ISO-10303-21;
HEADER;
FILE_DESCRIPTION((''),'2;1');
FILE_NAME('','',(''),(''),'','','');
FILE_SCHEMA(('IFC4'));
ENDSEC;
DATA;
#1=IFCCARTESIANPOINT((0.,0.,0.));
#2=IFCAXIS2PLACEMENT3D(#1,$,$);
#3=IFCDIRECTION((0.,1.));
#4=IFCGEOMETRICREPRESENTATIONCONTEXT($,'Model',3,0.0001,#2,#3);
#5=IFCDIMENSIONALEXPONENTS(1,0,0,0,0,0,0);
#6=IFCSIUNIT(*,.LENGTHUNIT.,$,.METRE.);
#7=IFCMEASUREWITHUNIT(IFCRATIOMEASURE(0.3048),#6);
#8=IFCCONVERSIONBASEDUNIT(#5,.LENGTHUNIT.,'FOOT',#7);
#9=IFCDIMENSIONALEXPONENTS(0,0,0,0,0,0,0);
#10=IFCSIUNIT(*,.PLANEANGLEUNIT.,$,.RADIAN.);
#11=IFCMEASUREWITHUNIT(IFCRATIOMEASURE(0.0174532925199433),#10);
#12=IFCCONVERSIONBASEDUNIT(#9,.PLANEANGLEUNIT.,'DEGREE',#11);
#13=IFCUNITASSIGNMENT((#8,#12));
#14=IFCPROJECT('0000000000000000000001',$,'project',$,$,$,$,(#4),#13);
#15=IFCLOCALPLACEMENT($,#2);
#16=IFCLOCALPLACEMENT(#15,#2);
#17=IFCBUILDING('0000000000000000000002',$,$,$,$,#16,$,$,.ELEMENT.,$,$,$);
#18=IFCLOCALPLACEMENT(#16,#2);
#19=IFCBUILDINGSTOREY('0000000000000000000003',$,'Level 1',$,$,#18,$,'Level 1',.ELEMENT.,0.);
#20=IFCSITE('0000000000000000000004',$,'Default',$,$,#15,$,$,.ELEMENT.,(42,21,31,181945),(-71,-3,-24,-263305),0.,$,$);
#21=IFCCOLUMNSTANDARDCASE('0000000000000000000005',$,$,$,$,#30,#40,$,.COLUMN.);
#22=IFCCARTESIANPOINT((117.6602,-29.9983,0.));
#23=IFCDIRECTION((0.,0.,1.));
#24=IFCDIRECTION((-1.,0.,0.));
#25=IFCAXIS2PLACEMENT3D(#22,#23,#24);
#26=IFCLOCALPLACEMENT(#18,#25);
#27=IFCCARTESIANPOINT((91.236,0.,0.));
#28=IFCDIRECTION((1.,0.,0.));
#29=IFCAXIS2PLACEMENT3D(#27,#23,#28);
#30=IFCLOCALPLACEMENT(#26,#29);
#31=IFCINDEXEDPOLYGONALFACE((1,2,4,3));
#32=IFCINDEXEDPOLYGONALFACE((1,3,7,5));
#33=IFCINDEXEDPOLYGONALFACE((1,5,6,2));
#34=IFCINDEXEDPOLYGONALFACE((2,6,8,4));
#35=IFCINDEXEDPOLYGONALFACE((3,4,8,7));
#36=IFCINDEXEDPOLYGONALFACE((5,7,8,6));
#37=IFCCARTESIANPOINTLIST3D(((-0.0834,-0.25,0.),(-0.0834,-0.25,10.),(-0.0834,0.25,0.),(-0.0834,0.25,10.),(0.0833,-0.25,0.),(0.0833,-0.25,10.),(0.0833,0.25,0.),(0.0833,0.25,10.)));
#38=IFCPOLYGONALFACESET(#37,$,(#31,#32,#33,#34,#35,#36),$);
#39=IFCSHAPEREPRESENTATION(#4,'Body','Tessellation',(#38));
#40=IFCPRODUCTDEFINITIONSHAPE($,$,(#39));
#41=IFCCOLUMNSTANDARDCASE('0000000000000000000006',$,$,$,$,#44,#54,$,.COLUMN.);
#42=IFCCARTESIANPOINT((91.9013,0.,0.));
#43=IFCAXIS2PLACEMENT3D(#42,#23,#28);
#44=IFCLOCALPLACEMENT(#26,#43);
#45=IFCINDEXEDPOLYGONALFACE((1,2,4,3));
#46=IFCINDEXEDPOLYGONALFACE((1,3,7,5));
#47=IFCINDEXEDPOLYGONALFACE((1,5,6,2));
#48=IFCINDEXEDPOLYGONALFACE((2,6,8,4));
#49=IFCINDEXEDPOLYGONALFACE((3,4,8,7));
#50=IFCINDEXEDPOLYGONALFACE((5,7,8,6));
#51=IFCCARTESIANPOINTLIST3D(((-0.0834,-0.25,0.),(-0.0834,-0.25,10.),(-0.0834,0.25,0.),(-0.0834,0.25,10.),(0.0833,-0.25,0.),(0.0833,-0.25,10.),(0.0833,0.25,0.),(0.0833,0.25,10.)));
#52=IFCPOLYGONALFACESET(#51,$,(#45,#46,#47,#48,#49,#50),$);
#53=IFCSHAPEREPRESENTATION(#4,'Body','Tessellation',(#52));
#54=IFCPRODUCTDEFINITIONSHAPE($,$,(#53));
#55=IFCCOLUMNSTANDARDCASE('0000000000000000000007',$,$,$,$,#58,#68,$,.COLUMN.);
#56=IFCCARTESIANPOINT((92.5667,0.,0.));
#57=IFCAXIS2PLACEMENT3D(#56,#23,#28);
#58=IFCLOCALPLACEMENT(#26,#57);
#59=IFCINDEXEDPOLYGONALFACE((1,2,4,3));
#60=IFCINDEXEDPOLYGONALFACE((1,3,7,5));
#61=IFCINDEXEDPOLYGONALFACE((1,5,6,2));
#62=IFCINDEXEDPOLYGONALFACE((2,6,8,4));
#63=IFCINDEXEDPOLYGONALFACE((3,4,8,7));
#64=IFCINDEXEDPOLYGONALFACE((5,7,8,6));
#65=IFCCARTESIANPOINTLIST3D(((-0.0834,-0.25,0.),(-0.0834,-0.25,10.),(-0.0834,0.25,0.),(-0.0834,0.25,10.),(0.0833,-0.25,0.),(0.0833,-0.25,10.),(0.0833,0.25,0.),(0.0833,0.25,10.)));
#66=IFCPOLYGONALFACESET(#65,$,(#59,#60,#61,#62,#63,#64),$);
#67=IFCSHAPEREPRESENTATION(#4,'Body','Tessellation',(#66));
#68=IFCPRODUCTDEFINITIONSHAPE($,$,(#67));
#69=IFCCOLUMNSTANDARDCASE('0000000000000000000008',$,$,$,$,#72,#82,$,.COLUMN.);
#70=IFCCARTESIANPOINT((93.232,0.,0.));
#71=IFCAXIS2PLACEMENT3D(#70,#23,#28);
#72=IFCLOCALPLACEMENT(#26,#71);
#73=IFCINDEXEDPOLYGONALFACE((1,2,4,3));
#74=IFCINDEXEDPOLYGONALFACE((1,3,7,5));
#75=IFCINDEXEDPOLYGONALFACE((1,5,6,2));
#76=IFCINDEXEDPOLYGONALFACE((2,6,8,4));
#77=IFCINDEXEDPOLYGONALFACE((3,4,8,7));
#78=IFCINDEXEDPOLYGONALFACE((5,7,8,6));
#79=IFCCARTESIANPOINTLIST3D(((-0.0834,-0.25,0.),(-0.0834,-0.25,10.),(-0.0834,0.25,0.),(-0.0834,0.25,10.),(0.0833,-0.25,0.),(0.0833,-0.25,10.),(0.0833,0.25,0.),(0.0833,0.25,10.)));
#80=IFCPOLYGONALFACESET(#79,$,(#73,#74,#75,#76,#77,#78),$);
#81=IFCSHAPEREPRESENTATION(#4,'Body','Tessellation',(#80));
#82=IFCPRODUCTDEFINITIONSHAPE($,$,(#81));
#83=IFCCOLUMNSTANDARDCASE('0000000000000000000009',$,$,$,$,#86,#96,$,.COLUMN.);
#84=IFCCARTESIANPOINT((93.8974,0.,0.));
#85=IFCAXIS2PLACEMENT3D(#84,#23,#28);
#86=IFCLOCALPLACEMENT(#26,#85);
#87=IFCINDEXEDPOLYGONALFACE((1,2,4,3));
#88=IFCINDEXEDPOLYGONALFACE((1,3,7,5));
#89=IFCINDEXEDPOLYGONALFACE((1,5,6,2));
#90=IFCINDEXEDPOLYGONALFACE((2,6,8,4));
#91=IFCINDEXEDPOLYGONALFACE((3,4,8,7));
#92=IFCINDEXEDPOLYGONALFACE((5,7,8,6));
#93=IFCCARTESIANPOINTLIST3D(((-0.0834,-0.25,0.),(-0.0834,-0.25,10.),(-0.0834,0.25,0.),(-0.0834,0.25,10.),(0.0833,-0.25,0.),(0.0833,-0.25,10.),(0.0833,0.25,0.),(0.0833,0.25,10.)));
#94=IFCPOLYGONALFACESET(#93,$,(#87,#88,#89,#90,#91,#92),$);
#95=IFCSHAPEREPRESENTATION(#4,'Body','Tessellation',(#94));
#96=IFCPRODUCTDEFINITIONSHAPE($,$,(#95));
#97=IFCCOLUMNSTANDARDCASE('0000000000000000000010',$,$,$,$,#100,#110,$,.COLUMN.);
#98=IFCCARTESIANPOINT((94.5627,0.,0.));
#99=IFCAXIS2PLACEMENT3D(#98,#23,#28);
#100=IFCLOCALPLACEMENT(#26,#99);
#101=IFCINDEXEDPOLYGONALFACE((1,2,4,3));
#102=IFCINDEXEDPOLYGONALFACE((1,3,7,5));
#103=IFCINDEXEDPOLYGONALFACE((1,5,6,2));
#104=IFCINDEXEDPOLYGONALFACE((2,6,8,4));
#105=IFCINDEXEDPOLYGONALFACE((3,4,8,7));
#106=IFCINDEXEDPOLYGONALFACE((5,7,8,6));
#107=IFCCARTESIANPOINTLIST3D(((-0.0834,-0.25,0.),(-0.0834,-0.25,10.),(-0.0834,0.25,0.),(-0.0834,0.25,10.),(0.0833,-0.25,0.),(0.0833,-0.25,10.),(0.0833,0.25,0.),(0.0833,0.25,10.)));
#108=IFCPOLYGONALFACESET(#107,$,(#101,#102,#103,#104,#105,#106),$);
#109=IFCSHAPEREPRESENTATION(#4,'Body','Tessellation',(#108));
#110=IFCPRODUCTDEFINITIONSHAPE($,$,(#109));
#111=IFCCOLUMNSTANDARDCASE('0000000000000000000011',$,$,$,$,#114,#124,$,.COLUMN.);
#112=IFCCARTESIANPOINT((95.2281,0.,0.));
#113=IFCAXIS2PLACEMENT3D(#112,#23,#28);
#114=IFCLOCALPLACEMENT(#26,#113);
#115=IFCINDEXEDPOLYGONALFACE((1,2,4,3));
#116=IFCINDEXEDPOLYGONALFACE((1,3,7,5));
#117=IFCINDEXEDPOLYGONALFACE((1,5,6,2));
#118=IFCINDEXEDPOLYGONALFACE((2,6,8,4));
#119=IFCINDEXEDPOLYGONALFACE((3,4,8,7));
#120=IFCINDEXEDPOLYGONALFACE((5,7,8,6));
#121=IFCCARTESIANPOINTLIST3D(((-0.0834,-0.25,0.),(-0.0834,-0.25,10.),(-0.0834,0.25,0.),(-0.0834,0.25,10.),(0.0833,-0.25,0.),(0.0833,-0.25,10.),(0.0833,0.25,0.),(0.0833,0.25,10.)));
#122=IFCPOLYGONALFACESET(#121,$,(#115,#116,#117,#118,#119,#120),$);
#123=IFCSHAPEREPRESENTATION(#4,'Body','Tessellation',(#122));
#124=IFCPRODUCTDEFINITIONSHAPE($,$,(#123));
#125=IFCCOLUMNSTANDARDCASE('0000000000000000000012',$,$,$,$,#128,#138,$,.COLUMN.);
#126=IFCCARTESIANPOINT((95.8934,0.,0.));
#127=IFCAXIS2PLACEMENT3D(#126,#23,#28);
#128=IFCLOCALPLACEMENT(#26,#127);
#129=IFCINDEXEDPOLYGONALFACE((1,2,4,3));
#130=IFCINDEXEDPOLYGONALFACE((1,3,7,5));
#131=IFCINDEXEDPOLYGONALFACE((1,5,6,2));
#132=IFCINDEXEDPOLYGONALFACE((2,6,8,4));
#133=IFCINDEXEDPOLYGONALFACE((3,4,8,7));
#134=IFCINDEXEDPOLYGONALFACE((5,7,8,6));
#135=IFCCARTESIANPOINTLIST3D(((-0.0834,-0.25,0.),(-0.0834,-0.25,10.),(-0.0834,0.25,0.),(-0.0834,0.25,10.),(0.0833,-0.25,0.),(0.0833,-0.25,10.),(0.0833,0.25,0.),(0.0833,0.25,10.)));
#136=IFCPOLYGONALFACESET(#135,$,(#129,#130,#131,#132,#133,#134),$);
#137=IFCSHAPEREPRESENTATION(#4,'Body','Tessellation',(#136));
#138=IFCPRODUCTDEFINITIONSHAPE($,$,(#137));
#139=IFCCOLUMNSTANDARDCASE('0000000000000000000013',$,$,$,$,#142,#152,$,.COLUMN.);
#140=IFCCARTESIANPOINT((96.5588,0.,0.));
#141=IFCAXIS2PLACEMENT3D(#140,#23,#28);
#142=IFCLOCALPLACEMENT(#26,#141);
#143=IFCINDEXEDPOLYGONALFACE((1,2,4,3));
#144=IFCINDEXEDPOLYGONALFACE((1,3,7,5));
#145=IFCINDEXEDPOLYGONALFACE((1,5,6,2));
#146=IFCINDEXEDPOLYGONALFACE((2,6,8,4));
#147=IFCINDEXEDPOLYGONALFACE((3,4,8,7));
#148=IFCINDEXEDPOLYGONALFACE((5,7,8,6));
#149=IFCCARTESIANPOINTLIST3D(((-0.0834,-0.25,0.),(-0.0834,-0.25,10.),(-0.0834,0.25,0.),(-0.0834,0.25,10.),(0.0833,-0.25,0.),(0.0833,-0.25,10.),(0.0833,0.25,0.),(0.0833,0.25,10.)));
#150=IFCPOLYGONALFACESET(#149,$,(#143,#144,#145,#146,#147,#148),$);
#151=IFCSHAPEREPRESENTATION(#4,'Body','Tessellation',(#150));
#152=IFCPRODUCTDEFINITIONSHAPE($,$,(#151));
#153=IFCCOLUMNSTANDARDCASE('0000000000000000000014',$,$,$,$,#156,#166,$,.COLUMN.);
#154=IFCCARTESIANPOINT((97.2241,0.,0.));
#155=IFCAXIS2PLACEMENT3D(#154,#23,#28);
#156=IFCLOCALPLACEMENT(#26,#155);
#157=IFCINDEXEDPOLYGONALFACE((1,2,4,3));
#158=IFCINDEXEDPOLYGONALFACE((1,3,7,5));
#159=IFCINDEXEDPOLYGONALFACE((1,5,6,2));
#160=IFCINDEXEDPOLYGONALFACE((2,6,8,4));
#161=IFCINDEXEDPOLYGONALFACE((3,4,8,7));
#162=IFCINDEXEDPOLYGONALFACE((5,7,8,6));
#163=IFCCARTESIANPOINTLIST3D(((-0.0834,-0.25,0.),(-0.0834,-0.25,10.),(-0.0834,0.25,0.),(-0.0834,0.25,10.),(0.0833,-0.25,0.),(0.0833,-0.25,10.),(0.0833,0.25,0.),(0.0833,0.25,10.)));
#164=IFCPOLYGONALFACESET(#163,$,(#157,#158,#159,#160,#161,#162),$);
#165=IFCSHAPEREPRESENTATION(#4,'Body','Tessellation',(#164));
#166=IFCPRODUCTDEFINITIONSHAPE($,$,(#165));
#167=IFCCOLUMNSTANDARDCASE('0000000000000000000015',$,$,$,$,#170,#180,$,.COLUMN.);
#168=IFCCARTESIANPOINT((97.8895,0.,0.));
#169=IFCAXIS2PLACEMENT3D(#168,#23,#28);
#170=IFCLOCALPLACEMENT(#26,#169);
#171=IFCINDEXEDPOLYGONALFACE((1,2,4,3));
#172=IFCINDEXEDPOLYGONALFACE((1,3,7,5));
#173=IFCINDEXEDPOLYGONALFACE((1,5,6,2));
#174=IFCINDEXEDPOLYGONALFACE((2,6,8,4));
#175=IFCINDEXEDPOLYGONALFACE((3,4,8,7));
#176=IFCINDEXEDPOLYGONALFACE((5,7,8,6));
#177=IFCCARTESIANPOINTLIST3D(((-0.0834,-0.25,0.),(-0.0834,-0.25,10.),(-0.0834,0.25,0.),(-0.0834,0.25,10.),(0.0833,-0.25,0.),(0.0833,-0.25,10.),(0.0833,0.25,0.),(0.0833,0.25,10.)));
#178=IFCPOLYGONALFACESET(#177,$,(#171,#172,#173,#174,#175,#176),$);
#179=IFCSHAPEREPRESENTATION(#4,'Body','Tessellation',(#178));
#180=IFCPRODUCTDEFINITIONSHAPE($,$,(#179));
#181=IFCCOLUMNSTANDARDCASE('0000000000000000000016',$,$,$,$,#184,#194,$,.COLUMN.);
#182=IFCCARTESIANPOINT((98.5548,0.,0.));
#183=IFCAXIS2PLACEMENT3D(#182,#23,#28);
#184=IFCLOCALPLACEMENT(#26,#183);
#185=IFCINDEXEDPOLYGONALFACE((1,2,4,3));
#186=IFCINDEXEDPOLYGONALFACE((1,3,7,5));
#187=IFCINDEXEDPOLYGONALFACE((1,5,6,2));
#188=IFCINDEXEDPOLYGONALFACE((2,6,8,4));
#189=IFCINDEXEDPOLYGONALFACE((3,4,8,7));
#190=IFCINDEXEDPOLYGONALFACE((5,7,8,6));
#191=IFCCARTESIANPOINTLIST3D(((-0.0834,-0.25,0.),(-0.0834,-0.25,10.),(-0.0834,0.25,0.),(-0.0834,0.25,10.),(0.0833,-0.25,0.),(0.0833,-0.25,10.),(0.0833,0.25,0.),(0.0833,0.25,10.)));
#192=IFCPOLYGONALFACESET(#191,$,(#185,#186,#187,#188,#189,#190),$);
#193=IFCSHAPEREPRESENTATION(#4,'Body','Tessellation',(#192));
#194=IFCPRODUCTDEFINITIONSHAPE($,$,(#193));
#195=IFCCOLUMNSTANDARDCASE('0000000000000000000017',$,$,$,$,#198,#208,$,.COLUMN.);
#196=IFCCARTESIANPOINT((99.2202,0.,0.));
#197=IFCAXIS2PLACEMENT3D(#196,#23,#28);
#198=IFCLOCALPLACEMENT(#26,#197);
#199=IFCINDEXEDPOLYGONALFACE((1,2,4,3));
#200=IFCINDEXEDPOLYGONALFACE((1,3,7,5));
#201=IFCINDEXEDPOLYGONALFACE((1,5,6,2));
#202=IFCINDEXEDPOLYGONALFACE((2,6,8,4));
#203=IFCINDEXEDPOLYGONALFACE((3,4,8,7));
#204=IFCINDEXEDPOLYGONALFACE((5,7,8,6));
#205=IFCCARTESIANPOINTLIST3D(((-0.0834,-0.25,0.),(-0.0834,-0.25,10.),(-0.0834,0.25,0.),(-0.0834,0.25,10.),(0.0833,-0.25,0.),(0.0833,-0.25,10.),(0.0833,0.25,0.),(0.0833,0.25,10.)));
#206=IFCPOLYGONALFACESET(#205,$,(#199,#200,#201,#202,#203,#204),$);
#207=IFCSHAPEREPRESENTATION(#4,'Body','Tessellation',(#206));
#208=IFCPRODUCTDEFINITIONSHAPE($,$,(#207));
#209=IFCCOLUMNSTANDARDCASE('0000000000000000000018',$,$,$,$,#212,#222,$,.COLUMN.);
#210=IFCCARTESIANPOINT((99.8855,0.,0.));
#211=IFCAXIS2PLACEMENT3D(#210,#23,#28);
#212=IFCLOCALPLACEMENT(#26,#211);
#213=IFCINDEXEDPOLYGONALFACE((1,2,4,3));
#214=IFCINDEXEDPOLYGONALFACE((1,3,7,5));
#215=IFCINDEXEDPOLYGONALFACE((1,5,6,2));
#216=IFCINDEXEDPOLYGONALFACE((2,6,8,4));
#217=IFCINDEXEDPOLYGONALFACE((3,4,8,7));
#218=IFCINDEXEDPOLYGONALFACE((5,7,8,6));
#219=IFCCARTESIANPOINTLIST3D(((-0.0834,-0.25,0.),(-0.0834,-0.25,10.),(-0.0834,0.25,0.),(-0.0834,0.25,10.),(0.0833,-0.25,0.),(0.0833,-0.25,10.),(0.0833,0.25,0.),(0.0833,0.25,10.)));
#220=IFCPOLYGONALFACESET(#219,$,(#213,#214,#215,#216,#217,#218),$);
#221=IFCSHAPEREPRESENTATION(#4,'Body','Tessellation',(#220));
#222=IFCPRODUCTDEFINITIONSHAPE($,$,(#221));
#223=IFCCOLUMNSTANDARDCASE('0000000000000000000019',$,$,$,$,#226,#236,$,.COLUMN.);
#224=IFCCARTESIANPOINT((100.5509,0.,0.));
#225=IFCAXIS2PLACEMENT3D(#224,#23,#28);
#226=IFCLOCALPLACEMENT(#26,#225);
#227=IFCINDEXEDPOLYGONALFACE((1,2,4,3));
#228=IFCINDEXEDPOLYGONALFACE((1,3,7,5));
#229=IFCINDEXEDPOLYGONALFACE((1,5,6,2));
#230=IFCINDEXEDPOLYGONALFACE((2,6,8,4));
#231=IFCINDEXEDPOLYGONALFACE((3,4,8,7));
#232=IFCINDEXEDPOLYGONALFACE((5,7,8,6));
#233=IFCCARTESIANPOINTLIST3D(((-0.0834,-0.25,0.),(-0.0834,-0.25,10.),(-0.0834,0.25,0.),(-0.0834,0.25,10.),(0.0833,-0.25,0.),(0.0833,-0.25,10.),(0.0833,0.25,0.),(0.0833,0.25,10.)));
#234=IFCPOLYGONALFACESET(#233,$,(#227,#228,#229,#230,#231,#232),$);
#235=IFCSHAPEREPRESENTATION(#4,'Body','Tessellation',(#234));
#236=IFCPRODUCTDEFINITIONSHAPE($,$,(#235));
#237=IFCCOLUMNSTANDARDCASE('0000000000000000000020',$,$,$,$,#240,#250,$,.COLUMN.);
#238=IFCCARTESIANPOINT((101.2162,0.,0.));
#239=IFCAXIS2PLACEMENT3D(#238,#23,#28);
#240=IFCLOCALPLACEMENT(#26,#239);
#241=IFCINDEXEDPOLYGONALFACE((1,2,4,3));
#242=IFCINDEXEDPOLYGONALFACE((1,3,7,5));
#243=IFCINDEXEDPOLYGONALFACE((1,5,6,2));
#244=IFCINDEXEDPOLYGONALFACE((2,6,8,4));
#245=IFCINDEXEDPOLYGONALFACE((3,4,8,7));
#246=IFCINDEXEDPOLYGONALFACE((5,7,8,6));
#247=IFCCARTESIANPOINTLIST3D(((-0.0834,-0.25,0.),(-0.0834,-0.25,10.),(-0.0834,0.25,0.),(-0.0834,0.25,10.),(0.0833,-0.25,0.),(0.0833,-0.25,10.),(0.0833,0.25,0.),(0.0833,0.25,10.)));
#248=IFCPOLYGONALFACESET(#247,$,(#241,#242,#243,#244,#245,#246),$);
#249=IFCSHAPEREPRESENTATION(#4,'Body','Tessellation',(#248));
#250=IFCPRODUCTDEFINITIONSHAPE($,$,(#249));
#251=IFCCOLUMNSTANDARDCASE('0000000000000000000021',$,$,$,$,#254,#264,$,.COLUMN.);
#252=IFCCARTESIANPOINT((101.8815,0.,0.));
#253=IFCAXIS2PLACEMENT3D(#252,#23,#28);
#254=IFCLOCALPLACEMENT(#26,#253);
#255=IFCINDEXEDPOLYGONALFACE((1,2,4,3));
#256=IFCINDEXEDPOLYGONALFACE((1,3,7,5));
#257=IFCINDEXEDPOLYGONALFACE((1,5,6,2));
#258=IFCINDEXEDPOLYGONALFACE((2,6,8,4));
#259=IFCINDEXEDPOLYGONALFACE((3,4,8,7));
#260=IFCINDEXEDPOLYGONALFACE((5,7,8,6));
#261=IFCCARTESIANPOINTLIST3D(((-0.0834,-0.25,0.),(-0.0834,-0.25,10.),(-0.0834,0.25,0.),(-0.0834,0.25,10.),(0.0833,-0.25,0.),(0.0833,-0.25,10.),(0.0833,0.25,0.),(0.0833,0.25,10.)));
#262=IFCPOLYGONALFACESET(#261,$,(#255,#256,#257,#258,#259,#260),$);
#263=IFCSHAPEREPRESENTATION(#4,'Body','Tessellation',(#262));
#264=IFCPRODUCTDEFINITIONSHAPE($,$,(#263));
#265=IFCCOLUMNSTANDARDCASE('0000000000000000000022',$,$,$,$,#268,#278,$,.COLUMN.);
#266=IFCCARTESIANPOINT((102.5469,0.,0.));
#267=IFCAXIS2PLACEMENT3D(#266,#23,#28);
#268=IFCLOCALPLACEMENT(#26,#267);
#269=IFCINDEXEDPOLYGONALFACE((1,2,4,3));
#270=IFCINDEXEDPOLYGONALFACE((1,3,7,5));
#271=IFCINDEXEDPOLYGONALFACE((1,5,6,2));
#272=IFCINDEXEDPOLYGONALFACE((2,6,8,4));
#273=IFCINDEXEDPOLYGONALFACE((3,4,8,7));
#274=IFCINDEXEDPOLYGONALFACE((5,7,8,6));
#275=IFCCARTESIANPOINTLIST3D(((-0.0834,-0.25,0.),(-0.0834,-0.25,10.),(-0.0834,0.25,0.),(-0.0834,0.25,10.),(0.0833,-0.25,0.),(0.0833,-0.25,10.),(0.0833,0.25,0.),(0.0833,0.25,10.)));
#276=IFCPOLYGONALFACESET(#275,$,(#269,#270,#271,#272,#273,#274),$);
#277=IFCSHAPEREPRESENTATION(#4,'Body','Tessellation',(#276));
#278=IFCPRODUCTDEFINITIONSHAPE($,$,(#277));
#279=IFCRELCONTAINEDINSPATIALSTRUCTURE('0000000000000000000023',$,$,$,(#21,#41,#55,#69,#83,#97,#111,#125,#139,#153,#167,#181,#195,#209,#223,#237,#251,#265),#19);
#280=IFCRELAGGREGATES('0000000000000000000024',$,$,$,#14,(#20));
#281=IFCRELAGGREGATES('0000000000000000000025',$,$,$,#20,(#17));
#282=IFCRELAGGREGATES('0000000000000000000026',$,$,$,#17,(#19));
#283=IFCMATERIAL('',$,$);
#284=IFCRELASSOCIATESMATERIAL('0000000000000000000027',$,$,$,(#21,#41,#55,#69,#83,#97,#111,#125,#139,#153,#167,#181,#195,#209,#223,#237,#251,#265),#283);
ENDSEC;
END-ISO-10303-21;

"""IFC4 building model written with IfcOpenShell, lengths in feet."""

from ifc_helpers import new_model, entity, si_unit, converted_unit, direction, frame, origin, place, context, project, spatial, rectangle, extrude, material, element, save


model = new_model("IFC4")

# Units and contexts
model_context = context("Model", 3, precision=0.0001, world=origin(), true_north=direction((0.0, 1.0)))
ifc_project = project(units=[converted_unit("LENGTHUNIT", "FOOT", entity("IfcRatioMeasure", 0.3048), si_unit("LENGTHUNIT", "METRE"), dimensions=[1, 0, 0, 0, 0, 0, 0]), converted_unit("PLANEANGLEUNIT", "DEGREE", entity("IfcRatioMeasure", 0.0174532925199433), si_unit("PLANEANGLEUNIT", "RADIAN"), dimensions=[0, 0, 0, 0, 0, 0, 0])], contexts=[model_context])

# Site, building, storey
site_placement = place(None, origin())
site = spatial("IfcSite", under=ifc_project, at=site_placement, Name="Default", CompositionType="ELEMENT", RefLatitude=(42, 21, 31, 181945), RefLongitude=(-71, -3, -24, -263305), RefElevation=0.0)
building_placement = place(site_placement, origin())
building = spatial("IfcBuilding", under=site, at=building_placement, CompositionType="ELEMENT")
storey_placement = place(building_placement, origin())
storey = spatial("IfcBuildingStorey", under=building, at=storey_placement, Name="Level 1", LongName="Level 1", CompositionType="ELEMENT", Elevation=0.0)

# Columns
ifc_material = material(Name="")
placement = place(storey_placement, frame((117.6602, -29.9983, 0.0), z_axis=(0.0, 0.0, 1.0), x_axis=(-1.0, 0.0, 0.0)))
for number, where, z_axis, x_axis in (
    (1, (91.236, 0.0, 0.0), (0.0, 0.0, 1.0), (1.0, 0.0, 0.0)),
    (2, (91.9013, 0.0, 0.0), (0.0, 0.0, 1.0), (1.0, 0.0, 0.0)),
    (3, (92.5667, 0.0, 0.0), (0.0, 0.0, 1.0), (1.0, 0.0, 0.0)),
    (4, (93.232, 0.0, 0.0), (0.0, 0.0, 1.0), (1.0, 0.0, 0.0)),
    (5, (93.8974, 0.0, 0.0), (0.0, 0.0, 1.0), (1.0, 0.0, 0.0)),
    (6, (94.5627, 0.0, 0.0), (0.0, 0.0, 1.0), (1.0, 0.0, 0.0)),
    (7, (95.2281, 0.0, 0.0), (0.0, 0.0, 1.0), (1.0, 0.0, 0.0)),
    (8, (95.8934, 0.0, 0.0), (0.0, 0.0, 1.0), (1.0, 0.0, 0.0)),
    (9, (96.5588, 0.0, 0.0), (0.0, 0.0, 1.0), (1.0, 0.0, 0.0)),
    (10, (97.2241, 0.0, 0.0), (0.0, 0.0, 1.0), (1.0, 0.0, 0.0)),
    (11, (97.8895, 0.0, 0.0), (0.0, 0.0, 1.0), (1.0, 0.0, 0.0)),
    (12, (98.5548, 0.0, 0.0), (0.0, 0.0, 1.0), (1.0, 0.0, 0.0)),
    (13, (99.2202, 0.0, 0.0), (0.0, 0.0, 1.0), (1.0, 0.0, 0.0)),
    (14, (99.8855, 0.0, 0.0), (0.0, 0.0, 1.0), (1.0, 0.0, 0.0)),
    (15, (100.5509, 0.0, 0.0), (0.0, 0.0, 1.0), (1.0, 0.0, 0.0)),
    (16, (101.2162, 0.0, 0.0), (0.0, 0.0, 1.0), (1.0, 0.0, 0.0)),
    (17, (101.8815, 0.0, 0.0), (0.0, 0.0, 1.0), (1.0, 0.0, 0.0)),
    (18, (102.5469, 0.0, 0.0), (0.0, 0.0, 1.0), (1.0, 0.0, 0.0)),
):
    element("IfcColumnStandardCase", number, at=place(placement, frame(where, z_axis=z_axis, x_axis=x_axis)), inside=storey, material=ifc_material, PredefinedType="COLUMN", context=model_context, shape_type="SweptSolid", body=[
        extrude(rectangle(XDim=0.1667, YDim=0.5), origin(), (0.0, 0.0, 1.0), 10.0),
    ])

save(model, "model.ifc")
